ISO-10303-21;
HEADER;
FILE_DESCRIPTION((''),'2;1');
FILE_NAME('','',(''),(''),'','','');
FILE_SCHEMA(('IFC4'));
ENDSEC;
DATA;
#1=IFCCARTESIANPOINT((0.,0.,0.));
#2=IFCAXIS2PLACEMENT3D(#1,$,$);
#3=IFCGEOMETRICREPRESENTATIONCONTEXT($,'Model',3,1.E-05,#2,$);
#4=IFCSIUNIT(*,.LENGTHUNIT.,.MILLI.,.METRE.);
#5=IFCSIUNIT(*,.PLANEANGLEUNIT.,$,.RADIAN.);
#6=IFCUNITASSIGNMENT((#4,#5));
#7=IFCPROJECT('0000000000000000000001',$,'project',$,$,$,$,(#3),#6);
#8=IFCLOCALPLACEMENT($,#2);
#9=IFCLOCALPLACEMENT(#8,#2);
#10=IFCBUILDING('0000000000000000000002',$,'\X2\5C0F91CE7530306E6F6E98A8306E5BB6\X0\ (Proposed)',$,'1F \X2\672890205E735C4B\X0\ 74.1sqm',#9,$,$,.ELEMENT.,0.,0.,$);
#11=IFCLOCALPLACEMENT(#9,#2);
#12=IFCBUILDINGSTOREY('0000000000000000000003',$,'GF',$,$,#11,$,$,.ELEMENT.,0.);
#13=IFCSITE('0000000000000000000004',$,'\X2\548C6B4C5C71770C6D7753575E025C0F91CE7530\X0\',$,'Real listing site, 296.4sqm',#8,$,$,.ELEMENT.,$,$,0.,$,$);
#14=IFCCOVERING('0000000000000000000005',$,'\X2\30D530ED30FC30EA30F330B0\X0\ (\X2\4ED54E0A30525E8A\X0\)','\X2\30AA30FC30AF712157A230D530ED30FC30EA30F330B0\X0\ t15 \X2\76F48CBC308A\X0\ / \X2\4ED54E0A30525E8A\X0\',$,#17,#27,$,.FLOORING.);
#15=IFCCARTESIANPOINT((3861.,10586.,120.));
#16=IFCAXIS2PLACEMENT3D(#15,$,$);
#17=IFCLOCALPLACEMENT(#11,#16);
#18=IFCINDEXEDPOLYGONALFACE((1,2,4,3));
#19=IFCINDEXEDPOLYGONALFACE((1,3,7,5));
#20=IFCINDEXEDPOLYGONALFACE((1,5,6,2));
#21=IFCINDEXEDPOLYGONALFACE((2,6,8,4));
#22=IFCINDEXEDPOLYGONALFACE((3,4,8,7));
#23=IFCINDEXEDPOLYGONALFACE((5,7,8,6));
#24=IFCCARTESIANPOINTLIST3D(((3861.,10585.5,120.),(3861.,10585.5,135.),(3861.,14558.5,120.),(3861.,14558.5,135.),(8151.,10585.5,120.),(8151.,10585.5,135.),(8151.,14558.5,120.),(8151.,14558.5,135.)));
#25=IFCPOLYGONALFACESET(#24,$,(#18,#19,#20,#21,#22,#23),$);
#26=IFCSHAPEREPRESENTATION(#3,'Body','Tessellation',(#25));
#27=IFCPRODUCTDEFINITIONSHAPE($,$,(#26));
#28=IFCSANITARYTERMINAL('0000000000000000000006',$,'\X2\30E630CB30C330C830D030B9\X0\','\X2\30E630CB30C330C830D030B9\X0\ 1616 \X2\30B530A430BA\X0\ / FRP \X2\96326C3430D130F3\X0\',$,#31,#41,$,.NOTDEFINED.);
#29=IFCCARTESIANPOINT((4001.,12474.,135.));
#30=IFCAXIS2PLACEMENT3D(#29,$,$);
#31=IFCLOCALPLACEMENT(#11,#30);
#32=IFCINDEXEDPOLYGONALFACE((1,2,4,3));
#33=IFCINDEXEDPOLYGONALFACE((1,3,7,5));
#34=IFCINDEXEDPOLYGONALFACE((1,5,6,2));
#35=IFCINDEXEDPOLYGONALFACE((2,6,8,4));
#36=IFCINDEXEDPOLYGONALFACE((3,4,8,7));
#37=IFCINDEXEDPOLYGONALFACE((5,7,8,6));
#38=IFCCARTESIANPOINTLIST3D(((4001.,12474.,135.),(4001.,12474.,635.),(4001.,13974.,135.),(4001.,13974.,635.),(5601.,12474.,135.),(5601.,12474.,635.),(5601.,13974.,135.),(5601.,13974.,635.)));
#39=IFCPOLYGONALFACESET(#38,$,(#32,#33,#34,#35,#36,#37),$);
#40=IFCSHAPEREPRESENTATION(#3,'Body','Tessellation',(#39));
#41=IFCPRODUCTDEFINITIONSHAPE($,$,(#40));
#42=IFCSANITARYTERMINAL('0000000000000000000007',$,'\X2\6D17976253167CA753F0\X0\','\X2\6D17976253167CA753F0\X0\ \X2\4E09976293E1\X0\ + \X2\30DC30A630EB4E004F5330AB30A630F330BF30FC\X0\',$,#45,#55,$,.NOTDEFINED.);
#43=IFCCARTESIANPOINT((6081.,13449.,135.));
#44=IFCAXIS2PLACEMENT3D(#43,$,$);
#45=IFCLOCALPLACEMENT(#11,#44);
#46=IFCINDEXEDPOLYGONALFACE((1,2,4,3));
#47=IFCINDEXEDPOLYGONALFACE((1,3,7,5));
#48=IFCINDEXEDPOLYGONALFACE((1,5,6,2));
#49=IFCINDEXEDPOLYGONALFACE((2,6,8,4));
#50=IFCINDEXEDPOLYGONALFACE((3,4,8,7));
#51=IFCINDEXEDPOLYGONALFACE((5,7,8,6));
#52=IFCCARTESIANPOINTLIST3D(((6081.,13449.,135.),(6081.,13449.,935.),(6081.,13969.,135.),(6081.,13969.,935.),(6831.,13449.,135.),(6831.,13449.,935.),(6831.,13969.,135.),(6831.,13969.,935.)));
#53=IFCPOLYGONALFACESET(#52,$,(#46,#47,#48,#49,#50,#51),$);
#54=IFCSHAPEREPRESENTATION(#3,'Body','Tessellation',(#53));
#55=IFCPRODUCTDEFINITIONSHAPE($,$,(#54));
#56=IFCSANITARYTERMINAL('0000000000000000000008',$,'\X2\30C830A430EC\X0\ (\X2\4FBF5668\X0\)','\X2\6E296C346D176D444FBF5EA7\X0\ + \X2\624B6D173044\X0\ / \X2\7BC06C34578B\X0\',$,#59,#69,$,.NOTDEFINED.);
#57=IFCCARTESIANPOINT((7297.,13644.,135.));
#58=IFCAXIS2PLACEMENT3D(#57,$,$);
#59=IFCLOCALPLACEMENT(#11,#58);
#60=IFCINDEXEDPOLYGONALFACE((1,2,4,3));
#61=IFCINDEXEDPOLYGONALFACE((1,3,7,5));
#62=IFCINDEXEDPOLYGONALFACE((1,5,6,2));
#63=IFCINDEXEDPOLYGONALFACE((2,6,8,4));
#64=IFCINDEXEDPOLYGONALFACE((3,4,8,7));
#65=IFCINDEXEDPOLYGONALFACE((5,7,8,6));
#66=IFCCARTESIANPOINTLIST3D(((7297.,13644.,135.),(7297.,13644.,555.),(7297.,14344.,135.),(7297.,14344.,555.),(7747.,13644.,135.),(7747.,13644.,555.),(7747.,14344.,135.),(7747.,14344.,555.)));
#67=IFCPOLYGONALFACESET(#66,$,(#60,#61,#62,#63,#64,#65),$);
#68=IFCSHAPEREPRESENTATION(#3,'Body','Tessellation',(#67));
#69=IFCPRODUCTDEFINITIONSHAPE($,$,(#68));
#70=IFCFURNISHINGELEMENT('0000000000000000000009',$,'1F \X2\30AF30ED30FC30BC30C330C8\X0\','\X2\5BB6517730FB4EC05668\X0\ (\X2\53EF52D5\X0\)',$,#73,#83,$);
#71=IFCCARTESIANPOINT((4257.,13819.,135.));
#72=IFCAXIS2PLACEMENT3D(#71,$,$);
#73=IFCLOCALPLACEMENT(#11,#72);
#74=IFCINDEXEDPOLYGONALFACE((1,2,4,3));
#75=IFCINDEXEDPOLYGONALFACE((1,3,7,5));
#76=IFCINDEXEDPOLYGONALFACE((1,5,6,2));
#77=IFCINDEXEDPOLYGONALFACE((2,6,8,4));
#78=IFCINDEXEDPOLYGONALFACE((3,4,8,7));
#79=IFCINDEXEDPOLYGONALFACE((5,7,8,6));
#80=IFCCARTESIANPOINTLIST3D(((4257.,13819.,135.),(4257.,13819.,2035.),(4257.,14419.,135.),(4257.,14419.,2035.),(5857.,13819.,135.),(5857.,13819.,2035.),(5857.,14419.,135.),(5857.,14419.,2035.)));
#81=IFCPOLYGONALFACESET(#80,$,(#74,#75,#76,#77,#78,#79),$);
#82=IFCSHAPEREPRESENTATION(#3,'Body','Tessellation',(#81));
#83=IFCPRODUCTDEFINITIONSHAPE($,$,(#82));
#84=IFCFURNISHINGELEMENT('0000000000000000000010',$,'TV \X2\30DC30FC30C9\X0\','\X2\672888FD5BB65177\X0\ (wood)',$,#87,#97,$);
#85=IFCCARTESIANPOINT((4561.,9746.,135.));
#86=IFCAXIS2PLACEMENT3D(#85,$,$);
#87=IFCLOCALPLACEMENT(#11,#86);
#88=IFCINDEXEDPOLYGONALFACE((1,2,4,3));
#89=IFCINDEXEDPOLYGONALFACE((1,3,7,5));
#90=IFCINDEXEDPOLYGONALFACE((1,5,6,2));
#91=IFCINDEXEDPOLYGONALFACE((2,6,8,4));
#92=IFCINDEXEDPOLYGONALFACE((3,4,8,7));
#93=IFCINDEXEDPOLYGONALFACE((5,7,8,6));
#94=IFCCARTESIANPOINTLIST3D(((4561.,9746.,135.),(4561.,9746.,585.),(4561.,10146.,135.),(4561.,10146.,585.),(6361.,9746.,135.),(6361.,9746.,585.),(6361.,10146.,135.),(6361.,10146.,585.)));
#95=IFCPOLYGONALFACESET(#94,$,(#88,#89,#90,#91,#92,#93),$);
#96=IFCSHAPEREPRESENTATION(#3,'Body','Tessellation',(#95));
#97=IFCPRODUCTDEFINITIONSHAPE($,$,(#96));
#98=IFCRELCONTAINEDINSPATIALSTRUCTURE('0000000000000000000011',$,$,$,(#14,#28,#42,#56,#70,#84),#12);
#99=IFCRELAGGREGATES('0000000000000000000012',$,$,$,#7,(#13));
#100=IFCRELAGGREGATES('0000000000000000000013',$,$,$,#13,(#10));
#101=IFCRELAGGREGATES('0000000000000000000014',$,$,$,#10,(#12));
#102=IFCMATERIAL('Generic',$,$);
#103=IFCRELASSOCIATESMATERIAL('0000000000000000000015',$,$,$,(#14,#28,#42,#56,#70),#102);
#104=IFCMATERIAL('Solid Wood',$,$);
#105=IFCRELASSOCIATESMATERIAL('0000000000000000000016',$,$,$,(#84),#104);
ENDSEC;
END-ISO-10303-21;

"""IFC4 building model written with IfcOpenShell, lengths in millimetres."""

from ifc_helpers import new_model, si_unit, frame, frame_2d, origin, place, context, project, spatial, rectangle, extrude, material, element, save


model = new_model("IFC4")

# Units and contexts
model_context = context("Model", 3, precision=1e-05, world=origin())
ifc_project = project(units=[si_unit("LENGTHUNIT", "METRE", prefix="MILLI"), si_unit("PLANEANGLEUNIT", "RADIAN")], contexts=[model_context])

# Site, building, storey
site_placement = place(None, origin())
site = spatial("IfcSite", under=ifc_project, at=site_placement, Name="和歌山県海南市小野田", ObjectType="Real listing site, 296.4sqm", CompositionType="ELEMENT", RefElevation=0.0)
building_placement = place(site_placement, origin())
building = spatial("IfcBuilding", under=site, at=building_placement, Name="小野田の潮風の家 (Proposed)", ObjectType="1F 木造平屋 74.1sqm", CompositionType="ELEMENT", ElevationOfRefHeight=0.0, ElevationOfTerrain=0.0)
storey_placement = place(building_placement, origin())
storey = spatial("IfcBuildingStorey", under=building, at=storey_placement, Name="GF", CompositionType="ELEMENT", Elevation=0.0)

# Shared definitions
ifc_material_1 = material(Name="Solid Wood")

# Covering
ifc_material_2 = material(Name="Generic")
covering_placement = place(storey_placement, frame((3861.0, 10586.0, 120.0)))
element("IfcCovering", 1, at=covering_placement, inside=storey, material=ifc_material_2, Name="フローリング (仕上げ床)", Description="オーク無垢フローリング t15 直貼り / 仕上げ床", PredefinedType="FLOORING", context=model_context, shape_type="SweptSolid", body=[
    extrude(rectangle(XDim=4290.0, YDim=3973.0, at=frame_2d((2145.0, 1986.0))), frame((3861.0, 10586.0, 120.0)), (0.0, 0.0, 1.0), 15.0),
])

# Sanitary terminals
sanitary_terminal_1_placement = place(storey_placement, frame((4001.0, 12474.0, 135.0)))
element("IfcSanitaryTerminal", 2, at=sanitary_terminal_1_placement, inside=storey, material=ifc_material_2, Name="ユニットバス", Description="ユニットバス 1616 サイズ / FRP 防水パン", PredefinedType="NOTDEFINED", context=model_context, shape_type="SweptSolid", body=[
    extrude(rectangle(XDim=1600.0, YDim=1500.0, at=frame_2d((800.0, 750.0))), frame((4001.0, 12474.0, 135.0)), (0.0, 0.0, 1.0), 500.0),
])
sanitary_terminal_2_placement = place(storey_placement, frame((6081.0, 13449.0, 135.0)))
element("IfcSanitaryTerminal", 3, at=sanitary_terminal_2_placement, inside=storey, material=ifc_material_2, Name="洗面化粧台", Description="洗面化粧台 三面鏡 + ボウル一体カウンター", PredefinedType="NOTDEFINED", context=model_context, shape_type="SweptSolid", body=[
    extrude(rectangle(XDim=750.0, YDim=520.0, at=frame_2d((375.0, 260.0))), frame((6081.0, 13449.0, 135.0)), (0.0, 0.0, 1.0), 800.0),
])
sanitary_terminal_3_placement = place(storey_placement, frame((7297.0, 13644.0, 135.0)))
element("IfcSanitaryTerminal", 4, at=sanitary_terminal_3_placement, inside=storey, material=ifc_material_2, Name="トイレ (便器)", Description="温水洗浄便座 + 手洗い / 節水型", PredefinedType="NOTDEFINED", context=model_context, shape_type="SweptSolid", body=[
    extrude(rectangle(XDim=450.0, YDim=700.0, at=frame_2d((225.0, 350.0))), frame((7297.0, 13644.0, 135.0)), (0.0, 0.0, 1.0), 420.0),
])

# Furnishing elements
furnishing_1_placement = place(storey_placement, frame((4257.0, 13819.0, 135.0)))
element("IfcFurnishingElement", 5, at=furnishing_1_placement, inside=storey, material=ifc_material_2, Name="1F クローゼット", Description="家具・什器 (可動)", context=model_context, shape_type="SweptSolid", body=[
    extrude(rectangle(XDim=1600.0, YDim=600.0, at=frame_2d((800.0, 300.0))), frame((4257.0, 13819.0, 135.0)), (0.0, 0.0, 1.0), 1900.0),
])
furnishing_2_placement = place(storey_placement, frame((4561.0, 9746.0, 135.0)))
element("IfcFurnishingElement", 6, at=furnishing_2_placement, inside=storey, material=ifc_material_1, Name="TV ボード", Description="木製家具 (wood)", context=model_context, shape_type="SweptSolid", body=[
    extrude(rectangle(XDim=1800.0, YDim=400.0, at=frame_2d((900.0, 200.0))), frame((4561.0, 9746.0, 135.0)), (0.0, 0.0, 1.0), 450.0),
])

save(model, "model.ifc")
